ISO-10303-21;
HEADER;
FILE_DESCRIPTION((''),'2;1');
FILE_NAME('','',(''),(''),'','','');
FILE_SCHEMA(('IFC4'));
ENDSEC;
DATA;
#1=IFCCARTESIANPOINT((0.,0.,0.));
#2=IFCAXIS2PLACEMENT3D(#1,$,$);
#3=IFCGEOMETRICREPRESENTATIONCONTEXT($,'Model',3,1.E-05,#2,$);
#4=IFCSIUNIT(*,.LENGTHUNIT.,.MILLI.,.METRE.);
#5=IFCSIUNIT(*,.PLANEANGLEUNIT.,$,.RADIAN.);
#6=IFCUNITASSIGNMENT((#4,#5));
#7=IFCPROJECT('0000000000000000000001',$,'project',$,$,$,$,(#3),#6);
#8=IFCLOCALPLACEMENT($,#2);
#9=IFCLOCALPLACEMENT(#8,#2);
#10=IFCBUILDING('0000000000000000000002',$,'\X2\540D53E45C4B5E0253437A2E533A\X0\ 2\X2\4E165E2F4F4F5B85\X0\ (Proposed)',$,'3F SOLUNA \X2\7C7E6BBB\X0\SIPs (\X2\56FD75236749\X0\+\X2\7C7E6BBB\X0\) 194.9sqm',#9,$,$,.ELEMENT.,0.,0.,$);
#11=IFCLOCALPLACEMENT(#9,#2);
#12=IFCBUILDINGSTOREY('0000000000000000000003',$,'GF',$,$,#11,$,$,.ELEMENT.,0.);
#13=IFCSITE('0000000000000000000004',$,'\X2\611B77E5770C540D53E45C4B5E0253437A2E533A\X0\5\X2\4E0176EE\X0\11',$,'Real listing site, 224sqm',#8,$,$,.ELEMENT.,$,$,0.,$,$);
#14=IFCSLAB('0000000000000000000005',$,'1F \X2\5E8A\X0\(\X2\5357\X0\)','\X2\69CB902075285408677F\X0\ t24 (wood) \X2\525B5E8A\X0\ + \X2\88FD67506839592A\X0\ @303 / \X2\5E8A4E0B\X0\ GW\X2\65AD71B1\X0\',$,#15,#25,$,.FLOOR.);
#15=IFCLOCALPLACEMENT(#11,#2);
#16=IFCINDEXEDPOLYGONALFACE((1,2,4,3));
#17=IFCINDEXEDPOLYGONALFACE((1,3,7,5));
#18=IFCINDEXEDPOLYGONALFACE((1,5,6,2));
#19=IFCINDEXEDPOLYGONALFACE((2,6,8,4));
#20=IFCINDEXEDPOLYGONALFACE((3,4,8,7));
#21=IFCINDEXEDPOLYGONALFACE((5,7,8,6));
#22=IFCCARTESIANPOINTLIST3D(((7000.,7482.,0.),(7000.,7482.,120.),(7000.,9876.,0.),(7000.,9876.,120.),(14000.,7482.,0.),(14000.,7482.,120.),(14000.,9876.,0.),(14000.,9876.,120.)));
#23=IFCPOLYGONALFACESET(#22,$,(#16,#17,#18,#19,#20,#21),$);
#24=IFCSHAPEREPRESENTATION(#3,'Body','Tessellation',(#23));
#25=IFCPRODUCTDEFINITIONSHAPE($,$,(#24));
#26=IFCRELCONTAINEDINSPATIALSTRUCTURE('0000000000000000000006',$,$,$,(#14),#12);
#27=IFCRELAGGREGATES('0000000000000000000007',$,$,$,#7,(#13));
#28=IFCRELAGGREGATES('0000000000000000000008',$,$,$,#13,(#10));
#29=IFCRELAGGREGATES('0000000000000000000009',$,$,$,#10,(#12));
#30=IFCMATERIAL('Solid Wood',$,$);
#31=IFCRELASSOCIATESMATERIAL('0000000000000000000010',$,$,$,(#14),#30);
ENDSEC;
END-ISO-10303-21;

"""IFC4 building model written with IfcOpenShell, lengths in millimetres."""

from ifc_helpers import new_model, si_unit, frame, frame_2d, origin, place, context, project, spatial, rectangle, extrude, material, element, save


model = new_model("IFC4")

# Units and contexts
model_context = context("Model", 3, precision=1e-05, world=origin())
ifc_project = project(units=[si_unit("LENGTHUNIT", "METRE", prefix="MILLI"), si_unit("PLANEANGLEUNIT", "RADIAN")], contexts=[model_context])

# Site, building, storey
site_placement = place(None, origin())
site = spatial("IfcSite", under=ifc_project, at=site_placement, Name="愛知県名古屋市千種区5丁目11", ObjectType="Real listing site, 224sqm", CompositionType="ELEMENT", RefElevation=0.0)
building_placement = place(site_placement, origin())
building = spatial("IfcBuilding", under=site, at=building_placement, Name="名古屋市千種区 2世帯住宅 (Proposed)", ObjectType="3F SOLUNA 籾殻SIPs (国産杉+籾殻) 194.9sqm", CompositionType="ELEMENT", ElevationOfRefHeight=0.0, ElevationOfTerrain=0.0)
storey_placement = place(building_placement, origin())
storey = spatial("IfcBuildingStorey", under=building, at=storey_placement, Name="GF", CompositionType="ELEMENT", Elevation=0.0)

# Slab
ifc_material_1 = material(Name="Solid Wood")
slab_1_placement = place(storey_placement, frame((3500.0, 3741.0, 0.0)))
element("IfcSlab", 1, at=slab_1_placement, inside=storey, material=ifc_material_1, Name="1F 床(南)", Description="構造用合板 t24 (wood) 剛床 + 製材根太 @303 / 床下 GW断熱", PredefinedType="FLOOR", context=model_context, shape_type="SweptSolid", body=[
    extrude(rectangle(XDim=7000.0, YDim=2394.0, at=frame_2d((3500.0, 1197.0))), frame((3500.0, 3741.0, 0.0)), (0.0, 0.0, 1.0), 120.0),
])

save(model, "model.ifc")
